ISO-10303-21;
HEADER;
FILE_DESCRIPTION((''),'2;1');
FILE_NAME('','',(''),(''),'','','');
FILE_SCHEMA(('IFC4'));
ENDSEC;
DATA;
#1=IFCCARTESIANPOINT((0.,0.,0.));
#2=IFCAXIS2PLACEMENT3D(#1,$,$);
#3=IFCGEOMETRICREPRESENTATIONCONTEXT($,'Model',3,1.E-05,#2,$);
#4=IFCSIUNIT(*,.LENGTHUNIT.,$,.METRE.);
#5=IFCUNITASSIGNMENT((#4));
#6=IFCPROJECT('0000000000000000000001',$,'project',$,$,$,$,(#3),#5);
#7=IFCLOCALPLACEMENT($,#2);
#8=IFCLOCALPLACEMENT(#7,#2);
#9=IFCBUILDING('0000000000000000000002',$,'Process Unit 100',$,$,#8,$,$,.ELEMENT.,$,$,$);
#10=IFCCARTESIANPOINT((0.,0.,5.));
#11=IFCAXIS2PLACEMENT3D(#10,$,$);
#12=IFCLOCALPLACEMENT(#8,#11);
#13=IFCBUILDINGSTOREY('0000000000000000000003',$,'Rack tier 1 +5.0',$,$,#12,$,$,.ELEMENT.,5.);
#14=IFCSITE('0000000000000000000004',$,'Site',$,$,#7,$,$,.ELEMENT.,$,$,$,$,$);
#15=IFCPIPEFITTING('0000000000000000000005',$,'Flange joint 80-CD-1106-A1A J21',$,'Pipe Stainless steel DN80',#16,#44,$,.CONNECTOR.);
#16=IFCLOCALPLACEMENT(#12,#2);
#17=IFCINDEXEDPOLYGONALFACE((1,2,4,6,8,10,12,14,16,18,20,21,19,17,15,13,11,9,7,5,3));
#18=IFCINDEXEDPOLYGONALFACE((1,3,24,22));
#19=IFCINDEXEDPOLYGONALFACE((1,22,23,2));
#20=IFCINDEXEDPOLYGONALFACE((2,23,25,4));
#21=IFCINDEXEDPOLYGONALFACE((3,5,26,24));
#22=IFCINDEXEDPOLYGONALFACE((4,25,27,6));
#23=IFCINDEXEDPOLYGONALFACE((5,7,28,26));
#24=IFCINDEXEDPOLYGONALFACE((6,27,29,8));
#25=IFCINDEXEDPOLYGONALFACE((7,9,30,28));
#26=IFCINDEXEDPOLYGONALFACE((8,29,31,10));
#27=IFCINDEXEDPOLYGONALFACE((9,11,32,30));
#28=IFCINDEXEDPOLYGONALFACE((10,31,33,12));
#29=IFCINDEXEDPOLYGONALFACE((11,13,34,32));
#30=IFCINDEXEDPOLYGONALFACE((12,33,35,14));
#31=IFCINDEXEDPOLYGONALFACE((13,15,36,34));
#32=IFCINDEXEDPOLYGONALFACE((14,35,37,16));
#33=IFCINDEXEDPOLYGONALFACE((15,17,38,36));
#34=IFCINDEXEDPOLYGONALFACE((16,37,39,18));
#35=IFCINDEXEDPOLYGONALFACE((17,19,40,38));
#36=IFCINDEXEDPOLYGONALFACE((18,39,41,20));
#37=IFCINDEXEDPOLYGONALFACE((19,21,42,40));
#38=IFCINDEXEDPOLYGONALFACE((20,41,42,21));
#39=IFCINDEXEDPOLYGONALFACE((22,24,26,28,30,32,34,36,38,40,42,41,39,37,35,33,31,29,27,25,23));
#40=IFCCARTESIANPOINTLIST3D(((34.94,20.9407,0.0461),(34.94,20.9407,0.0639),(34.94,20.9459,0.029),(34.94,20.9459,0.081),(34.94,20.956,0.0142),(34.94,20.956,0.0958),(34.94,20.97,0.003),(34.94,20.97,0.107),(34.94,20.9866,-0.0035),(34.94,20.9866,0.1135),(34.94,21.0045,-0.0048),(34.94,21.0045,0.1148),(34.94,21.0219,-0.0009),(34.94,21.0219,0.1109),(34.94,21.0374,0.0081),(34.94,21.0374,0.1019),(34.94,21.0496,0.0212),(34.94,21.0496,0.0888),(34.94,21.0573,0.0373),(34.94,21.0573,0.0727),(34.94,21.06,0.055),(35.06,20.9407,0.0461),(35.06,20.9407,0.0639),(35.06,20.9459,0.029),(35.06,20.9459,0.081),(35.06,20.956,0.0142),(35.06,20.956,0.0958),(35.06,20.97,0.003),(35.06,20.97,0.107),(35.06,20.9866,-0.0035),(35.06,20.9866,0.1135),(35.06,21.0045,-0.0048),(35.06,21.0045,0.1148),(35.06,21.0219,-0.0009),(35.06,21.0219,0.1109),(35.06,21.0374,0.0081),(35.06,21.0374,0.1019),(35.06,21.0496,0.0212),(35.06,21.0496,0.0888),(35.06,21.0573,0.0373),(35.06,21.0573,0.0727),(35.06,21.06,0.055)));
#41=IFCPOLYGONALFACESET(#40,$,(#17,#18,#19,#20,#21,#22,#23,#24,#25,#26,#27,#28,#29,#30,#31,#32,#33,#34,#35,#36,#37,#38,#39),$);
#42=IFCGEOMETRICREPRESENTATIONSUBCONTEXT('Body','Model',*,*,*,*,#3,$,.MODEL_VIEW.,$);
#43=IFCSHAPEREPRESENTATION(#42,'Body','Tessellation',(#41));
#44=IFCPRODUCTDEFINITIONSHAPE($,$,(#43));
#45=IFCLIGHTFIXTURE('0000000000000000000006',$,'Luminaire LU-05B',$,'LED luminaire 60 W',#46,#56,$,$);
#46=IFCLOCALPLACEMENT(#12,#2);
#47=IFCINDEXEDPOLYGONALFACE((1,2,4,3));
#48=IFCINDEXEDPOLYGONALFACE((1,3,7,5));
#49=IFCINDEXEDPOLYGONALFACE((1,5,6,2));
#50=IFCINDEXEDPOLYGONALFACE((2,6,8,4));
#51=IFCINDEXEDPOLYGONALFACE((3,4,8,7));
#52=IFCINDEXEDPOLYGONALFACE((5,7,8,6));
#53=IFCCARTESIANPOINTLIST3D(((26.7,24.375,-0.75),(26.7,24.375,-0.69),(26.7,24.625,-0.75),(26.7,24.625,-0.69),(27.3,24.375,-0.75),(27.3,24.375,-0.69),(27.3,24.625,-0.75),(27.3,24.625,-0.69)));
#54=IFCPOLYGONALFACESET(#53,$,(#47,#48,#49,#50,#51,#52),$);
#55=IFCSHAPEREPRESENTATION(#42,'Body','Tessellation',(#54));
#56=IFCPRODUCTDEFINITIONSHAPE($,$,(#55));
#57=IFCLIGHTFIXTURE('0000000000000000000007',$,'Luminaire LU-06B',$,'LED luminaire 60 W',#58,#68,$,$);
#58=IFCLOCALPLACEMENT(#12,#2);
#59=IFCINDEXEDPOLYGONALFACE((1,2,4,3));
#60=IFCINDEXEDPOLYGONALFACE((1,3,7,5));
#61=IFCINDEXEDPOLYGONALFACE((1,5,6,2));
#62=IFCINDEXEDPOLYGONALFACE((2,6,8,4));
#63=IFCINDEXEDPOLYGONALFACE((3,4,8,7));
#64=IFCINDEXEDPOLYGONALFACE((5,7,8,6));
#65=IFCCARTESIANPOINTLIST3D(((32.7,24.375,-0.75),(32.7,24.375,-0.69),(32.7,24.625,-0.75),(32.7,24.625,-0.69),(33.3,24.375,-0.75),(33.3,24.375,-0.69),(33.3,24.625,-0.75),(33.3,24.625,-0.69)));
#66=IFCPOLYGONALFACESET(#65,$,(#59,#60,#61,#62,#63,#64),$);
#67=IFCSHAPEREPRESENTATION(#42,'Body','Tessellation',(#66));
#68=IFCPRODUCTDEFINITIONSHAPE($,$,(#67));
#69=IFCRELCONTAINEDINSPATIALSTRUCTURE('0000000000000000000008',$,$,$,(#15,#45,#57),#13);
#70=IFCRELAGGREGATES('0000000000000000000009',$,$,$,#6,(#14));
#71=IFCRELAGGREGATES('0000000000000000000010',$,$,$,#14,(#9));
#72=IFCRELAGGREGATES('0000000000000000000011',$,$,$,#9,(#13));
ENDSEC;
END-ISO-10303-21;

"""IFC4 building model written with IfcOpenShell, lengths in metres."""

from ifc_helpers import new_model, si_unit, frame, origin, place, context, subcontext, project, spatial, rectangle, circle, extrude, element, save


model = new_model("IFC4")

# Units and contexts
model_context = context("Model", 3, precision=1e-05, world=origin())
body_context = subcontext(model_context, "Body", "Model", "MODEL_VIEW")
ifc_project = project(units=[si_unit("LENGTHUNIT", "METRE")], contexts=[model_context])

# Site, building, storey
site_placement = place(None, origin())
site = spatial("IfcSite", under=ifc_project, at=site_placement, Name="Site", CompositionType="ELEMENT")
building_placement = place(site_placement, origin())
building = spatial("IfcBuilding", under=site, at=building_placement, Name="Process Unit 100", CompositionType="ELEMENT")
storey_placement = place(building_placement, frame((0.0, 0.0, 5.0)))
storey = spatial("IfcBuildingStorey", under=building, at=storey_placement, Name="Rack tier 1 +5.0", CompositionType="ELEMENT", Elevation=5.0)

# Pipe fitting
for number, where, z_axis, x_axis, name in (
    (1, (34.94, 21.0, 0.055), (1.0, 0.0, 0.0), (0.0, 1.0, 0.0), "Flange joint 80-CD-1106-A1A J21"),
):
    element("IfcPipeFitting", number, at=place(storey_placement, frame(where, z_axis=z_axis, x_axis=x_axis)), inside=storey, Name=name, ObjectType="Pipe Stainless steel DN80", PredefinedType="CONNECTOR", context=body_context, shape_type="SweptSolid", body=[
        extrude(circle(Radius=0.06), origin(), (0.0, 0.0, 1.0), 0.12),
    ])

# Light fixtures
for number, where, z_axis, x_axis, name in (
    (2, (27.0, 24.5, -0.75), (0.0, 0.0, 1.0), (1.0, 0.0, 0.0), "Luminaire LU-05B"),
    (3, (33.0, 24.5, -0.75), (0.0, 0.0, 1.0), (1.0, 0.0, 0.0), "Luminaire LU-06B"),
):
    element("IfcLightFixture", number, at=place(storey_placement, frame(where, z_axis=z_axis, x_axis=x_axis)), inside=storey, Name=name, ObjectType="LED luminaire 60 W", context=body_context, shape_type="SweptSolid", body=[
        extrude(rectangle(XDim=0.6, YDim=0.25), origin(), (0.0, 0.0, 1.0), 0.06),
    ])

save(model, "model.ifc")
